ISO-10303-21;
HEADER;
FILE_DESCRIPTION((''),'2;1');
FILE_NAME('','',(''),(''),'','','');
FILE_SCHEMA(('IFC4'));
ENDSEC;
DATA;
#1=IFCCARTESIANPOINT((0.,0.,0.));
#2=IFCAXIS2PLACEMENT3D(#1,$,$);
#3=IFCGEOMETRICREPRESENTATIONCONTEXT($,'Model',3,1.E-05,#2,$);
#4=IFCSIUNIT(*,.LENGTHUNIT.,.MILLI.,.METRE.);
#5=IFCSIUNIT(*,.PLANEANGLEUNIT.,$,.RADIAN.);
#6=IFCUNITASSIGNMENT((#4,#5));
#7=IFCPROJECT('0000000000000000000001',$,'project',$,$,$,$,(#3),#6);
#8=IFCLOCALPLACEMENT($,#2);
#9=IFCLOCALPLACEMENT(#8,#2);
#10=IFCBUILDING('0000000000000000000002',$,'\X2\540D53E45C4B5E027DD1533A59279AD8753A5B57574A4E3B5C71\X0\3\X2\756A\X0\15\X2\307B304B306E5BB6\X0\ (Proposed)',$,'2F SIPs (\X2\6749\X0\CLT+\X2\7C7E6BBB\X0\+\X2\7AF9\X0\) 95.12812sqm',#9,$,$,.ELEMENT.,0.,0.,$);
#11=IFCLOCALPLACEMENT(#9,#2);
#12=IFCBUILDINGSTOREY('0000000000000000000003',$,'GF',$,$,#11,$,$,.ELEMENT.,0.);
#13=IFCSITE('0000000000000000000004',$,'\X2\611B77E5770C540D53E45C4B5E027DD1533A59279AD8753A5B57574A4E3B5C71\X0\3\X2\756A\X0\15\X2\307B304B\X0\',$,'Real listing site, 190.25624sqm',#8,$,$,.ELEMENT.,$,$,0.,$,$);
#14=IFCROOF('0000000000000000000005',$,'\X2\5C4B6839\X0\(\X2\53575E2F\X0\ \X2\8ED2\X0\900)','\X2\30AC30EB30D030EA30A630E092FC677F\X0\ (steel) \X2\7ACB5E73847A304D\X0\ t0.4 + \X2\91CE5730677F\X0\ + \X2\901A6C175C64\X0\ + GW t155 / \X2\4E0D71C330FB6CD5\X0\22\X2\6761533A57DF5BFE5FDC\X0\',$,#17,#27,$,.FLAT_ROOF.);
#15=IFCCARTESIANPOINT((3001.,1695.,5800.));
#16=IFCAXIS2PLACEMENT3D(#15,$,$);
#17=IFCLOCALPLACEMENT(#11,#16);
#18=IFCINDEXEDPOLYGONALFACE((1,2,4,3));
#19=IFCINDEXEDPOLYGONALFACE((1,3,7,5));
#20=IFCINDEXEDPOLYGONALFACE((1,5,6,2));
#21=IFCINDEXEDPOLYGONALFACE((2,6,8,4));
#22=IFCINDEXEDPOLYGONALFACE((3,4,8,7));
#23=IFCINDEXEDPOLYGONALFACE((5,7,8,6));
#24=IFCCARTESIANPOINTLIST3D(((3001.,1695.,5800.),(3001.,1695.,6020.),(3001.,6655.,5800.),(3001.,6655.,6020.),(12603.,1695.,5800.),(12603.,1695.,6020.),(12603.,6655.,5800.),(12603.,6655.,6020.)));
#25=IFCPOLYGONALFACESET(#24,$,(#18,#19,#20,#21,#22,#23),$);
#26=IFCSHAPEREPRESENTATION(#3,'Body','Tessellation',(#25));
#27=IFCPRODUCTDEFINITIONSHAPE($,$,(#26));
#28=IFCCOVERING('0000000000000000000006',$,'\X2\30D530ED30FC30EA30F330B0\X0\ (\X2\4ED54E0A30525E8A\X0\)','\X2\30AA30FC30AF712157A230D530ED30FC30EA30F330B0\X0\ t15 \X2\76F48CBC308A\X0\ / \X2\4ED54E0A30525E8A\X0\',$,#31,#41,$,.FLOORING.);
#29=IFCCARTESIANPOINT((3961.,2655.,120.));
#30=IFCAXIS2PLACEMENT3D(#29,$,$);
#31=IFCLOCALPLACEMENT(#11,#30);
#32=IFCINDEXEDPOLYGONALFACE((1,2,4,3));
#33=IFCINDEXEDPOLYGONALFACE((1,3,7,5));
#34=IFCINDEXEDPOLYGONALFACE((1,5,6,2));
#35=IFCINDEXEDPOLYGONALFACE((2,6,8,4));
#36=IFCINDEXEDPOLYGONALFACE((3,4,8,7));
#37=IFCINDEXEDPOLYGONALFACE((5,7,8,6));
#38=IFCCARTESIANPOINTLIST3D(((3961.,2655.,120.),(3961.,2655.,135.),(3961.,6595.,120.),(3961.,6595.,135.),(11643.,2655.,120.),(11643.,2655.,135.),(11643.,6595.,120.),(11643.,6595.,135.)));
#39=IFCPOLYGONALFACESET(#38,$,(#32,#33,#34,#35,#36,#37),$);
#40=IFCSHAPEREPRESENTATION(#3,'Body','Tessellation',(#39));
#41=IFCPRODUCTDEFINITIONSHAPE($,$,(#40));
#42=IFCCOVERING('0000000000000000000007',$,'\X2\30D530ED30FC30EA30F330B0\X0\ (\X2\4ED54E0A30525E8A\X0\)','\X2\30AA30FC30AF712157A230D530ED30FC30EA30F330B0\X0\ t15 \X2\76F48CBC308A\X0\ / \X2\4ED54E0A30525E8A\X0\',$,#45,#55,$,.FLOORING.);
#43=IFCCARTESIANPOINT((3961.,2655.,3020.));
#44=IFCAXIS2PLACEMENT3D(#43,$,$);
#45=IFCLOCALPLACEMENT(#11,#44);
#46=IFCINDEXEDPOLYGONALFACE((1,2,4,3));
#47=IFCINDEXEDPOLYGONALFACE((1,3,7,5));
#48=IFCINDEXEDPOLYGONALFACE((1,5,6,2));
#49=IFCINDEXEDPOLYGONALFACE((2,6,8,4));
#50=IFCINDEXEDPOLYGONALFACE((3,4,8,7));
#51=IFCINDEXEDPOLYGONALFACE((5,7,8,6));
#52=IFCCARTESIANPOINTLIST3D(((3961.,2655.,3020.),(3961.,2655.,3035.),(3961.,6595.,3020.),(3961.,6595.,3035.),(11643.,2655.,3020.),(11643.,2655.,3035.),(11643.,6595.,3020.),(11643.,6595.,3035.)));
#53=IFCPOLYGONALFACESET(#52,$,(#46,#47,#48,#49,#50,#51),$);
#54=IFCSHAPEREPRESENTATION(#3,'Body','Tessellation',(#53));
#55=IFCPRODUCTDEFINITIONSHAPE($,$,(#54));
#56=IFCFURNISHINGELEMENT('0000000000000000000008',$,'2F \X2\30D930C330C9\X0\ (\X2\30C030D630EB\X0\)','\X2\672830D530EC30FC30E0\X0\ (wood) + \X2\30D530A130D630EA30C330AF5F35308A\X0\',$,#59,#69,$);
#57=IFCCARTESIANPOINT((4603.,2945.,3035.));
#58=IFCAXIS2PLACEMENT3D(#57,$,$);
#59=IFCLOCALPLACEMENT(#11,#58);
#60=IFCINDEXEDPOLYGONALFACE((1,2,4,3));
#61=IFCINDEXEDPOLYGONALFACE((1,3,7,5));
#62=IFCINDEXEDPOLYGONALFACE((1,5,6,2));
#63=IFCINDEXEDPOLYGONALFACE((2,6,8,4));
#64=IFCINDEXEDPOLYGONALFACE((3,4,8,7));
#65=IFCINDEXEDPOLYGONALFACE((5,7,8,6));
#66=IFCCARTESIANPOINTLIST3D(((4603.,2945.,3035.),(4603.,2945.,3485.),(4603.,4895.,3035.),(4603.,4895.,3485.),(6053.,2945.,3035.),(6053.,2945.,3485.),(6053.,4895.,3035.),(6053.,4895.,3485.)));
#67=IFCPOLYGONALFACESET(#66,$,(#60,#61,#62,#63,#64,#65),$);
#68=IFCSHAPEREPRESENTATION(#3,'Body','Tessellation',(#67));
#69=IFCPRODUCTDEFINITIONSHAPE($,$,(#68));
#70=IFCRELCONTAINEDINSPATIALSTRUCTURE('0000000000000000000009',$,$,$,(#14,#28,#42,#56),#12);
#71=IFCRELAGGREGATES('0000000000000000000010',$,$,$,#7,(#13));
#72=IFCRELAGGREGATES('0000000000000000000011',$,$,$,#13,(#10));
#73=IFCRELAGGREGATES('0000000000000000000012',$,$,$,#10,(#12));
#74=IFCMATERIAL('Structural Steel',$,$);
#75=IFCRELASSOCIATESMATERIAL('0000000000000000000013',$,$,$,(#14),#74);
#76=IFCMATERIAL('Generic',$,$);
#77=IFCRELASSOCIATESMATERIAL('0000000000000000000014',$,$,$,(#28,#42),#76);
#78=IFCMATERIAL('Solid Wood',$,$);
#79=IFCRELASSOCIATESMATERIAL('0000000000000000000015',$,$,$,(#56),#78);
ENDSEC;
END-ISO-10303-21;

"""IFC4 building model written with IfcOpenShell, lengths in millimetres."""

from ifc_helpers import new_model, si_unit, frame, frame_2d, origin, place, context, project, spatial, rectangle, extrude, material, element, save


model = new_model("IFC4")

# Units and contexts
model_context = context("Model", 3, precision=1e-05, world=origin())
ifc_project = project(units=[si_unit("LENGTHUNIT", "METRE", prefix="MILLI"), si_unit("PLANEANGLEUNIT", "RADIAN")], contexts=[model_context])

# Site, building, storey
site_placement = place(None, origin())
site = spatial("IfcSite", under=ifc_project, at=site_placement, Name="愛知県名古屋市緑区大高町字坊主山3番15ほか", ObjectType="Real listing site, 190.25624sqm", CompositionType="ELEMENT", RefElevation=0.0)
building_placement = place(site_placement, origin())
building = spatial("IfcBuilding", under=site, at=building_placement, Name="名古屋市緑区大高町字坊主山3番15ほかの家 (Proposed)", ObjectType="2F SIPs (杉CLT+籾殻+竹) 95.12812sqm", CompositionType="ELEMENT", ElevationOfRefHeight=0.0, ElevationOfTerrain=0.0)
storey_placement = place(building_placement, origin())
storey = spatial("IfcBuildingStorey", under=building, at=storey_placement, Name="GF", CompositionType="ELEMENT", Elevation=0.0)

# Shared definitions
ifc_material_1 = material(Name="Solid Wood")

# Roof
ifc_material_2 = material(Name="Structural Steel")
for number, where, name in (
    (1, (3001.0, 1695.0, 5800.0), "屋根(南帯 軒900)"),
):
    element("IfcRoof", number, at=place(storey_placement, frame(where)), inside=storey, material=ifc_material_2, Name=name, Description="ガルバリウム鋼板 (steel) 立平葺き t0.4 + 野地板 + 通気層 + GW t155 / 不燃・法22条区域対応", PredefinedType="FLAT_ROOF", context=model_context, shape_type="SweptSolid", body=[
        extrude(rectangle(XDim=9602.0, YDim=4960.0, at=frame_2d((4801.0, 2480.0))), frame((3001.0, 1695.0, 5800.0)), (0.0, 0.0, 1.0), 220.0),
    ])

# Coverings
ifc_material_3 = material(Name="Generic")
covering_1_placement = place(storey_placement, frame((3961.0, 2655.0, 120.0)))
element("IfcCovering", 2, at=covering_1_placement, inside=storey, material=ifc_material_3, Name="フローリング (仕上げ床)", Description="オーク無垢フローリング t15 直貼り / 仕上げ床", PredefinedType="FLOORING", context=model_context, shape_type="SweptSolid", body=[
    extrude(rectangle(XDim=7682.0, YDim=3940.0, at=frame_2d((3841.0, 1970.0))), frame((3961.0, 2655.0, 120.0)), (0.0, 0.0, 1.0), 15.0),
])
covering_2_placement = place(storey_placement, frame((3961.0, 2655.0, 3020.0)))
element("IfcCovering", 3, at=covering_2_placement, inside=storey, material=ifc_material_3, Name="フローリング (仕上げ床)", Description="オーク無垢フローリング t15 直貼り / 仕上げ床", PredefinedType="FLOORING", context=model_context, shape_type="SweptSolid", body=[
    extrude(rectangle(XDim=7682.0, YDim=3940.0, at=frame_2d((3841.0, 1970.0))), frame((3961.0, 2655.0, 3020.0)), (0.0, 0.0, 1.0), 15.0),
])

# Furnishing element
furnishing_placement = place(storey_placement, frame((4603.0, 2945.0, 3035.0)))
element("IfcFurnishingElement", 4, at=furnishing_placement, inside=storey, material=ifc_material_1, Name="2F ベッド (ダブル)", Description="木フレーム (wood) + ファブリック張り", context=model_context, shape_type="SweptSolid", body=[
    extrude(rectangle(XDim=1450.0, YDim=1950.0, at=frame_2d((725.0, 975.0))), frame((4603.0, 2945.0, 3035.0)), (0.0, 0.0, 1.0), 450.0),
])

save(model, "model.ifc")
